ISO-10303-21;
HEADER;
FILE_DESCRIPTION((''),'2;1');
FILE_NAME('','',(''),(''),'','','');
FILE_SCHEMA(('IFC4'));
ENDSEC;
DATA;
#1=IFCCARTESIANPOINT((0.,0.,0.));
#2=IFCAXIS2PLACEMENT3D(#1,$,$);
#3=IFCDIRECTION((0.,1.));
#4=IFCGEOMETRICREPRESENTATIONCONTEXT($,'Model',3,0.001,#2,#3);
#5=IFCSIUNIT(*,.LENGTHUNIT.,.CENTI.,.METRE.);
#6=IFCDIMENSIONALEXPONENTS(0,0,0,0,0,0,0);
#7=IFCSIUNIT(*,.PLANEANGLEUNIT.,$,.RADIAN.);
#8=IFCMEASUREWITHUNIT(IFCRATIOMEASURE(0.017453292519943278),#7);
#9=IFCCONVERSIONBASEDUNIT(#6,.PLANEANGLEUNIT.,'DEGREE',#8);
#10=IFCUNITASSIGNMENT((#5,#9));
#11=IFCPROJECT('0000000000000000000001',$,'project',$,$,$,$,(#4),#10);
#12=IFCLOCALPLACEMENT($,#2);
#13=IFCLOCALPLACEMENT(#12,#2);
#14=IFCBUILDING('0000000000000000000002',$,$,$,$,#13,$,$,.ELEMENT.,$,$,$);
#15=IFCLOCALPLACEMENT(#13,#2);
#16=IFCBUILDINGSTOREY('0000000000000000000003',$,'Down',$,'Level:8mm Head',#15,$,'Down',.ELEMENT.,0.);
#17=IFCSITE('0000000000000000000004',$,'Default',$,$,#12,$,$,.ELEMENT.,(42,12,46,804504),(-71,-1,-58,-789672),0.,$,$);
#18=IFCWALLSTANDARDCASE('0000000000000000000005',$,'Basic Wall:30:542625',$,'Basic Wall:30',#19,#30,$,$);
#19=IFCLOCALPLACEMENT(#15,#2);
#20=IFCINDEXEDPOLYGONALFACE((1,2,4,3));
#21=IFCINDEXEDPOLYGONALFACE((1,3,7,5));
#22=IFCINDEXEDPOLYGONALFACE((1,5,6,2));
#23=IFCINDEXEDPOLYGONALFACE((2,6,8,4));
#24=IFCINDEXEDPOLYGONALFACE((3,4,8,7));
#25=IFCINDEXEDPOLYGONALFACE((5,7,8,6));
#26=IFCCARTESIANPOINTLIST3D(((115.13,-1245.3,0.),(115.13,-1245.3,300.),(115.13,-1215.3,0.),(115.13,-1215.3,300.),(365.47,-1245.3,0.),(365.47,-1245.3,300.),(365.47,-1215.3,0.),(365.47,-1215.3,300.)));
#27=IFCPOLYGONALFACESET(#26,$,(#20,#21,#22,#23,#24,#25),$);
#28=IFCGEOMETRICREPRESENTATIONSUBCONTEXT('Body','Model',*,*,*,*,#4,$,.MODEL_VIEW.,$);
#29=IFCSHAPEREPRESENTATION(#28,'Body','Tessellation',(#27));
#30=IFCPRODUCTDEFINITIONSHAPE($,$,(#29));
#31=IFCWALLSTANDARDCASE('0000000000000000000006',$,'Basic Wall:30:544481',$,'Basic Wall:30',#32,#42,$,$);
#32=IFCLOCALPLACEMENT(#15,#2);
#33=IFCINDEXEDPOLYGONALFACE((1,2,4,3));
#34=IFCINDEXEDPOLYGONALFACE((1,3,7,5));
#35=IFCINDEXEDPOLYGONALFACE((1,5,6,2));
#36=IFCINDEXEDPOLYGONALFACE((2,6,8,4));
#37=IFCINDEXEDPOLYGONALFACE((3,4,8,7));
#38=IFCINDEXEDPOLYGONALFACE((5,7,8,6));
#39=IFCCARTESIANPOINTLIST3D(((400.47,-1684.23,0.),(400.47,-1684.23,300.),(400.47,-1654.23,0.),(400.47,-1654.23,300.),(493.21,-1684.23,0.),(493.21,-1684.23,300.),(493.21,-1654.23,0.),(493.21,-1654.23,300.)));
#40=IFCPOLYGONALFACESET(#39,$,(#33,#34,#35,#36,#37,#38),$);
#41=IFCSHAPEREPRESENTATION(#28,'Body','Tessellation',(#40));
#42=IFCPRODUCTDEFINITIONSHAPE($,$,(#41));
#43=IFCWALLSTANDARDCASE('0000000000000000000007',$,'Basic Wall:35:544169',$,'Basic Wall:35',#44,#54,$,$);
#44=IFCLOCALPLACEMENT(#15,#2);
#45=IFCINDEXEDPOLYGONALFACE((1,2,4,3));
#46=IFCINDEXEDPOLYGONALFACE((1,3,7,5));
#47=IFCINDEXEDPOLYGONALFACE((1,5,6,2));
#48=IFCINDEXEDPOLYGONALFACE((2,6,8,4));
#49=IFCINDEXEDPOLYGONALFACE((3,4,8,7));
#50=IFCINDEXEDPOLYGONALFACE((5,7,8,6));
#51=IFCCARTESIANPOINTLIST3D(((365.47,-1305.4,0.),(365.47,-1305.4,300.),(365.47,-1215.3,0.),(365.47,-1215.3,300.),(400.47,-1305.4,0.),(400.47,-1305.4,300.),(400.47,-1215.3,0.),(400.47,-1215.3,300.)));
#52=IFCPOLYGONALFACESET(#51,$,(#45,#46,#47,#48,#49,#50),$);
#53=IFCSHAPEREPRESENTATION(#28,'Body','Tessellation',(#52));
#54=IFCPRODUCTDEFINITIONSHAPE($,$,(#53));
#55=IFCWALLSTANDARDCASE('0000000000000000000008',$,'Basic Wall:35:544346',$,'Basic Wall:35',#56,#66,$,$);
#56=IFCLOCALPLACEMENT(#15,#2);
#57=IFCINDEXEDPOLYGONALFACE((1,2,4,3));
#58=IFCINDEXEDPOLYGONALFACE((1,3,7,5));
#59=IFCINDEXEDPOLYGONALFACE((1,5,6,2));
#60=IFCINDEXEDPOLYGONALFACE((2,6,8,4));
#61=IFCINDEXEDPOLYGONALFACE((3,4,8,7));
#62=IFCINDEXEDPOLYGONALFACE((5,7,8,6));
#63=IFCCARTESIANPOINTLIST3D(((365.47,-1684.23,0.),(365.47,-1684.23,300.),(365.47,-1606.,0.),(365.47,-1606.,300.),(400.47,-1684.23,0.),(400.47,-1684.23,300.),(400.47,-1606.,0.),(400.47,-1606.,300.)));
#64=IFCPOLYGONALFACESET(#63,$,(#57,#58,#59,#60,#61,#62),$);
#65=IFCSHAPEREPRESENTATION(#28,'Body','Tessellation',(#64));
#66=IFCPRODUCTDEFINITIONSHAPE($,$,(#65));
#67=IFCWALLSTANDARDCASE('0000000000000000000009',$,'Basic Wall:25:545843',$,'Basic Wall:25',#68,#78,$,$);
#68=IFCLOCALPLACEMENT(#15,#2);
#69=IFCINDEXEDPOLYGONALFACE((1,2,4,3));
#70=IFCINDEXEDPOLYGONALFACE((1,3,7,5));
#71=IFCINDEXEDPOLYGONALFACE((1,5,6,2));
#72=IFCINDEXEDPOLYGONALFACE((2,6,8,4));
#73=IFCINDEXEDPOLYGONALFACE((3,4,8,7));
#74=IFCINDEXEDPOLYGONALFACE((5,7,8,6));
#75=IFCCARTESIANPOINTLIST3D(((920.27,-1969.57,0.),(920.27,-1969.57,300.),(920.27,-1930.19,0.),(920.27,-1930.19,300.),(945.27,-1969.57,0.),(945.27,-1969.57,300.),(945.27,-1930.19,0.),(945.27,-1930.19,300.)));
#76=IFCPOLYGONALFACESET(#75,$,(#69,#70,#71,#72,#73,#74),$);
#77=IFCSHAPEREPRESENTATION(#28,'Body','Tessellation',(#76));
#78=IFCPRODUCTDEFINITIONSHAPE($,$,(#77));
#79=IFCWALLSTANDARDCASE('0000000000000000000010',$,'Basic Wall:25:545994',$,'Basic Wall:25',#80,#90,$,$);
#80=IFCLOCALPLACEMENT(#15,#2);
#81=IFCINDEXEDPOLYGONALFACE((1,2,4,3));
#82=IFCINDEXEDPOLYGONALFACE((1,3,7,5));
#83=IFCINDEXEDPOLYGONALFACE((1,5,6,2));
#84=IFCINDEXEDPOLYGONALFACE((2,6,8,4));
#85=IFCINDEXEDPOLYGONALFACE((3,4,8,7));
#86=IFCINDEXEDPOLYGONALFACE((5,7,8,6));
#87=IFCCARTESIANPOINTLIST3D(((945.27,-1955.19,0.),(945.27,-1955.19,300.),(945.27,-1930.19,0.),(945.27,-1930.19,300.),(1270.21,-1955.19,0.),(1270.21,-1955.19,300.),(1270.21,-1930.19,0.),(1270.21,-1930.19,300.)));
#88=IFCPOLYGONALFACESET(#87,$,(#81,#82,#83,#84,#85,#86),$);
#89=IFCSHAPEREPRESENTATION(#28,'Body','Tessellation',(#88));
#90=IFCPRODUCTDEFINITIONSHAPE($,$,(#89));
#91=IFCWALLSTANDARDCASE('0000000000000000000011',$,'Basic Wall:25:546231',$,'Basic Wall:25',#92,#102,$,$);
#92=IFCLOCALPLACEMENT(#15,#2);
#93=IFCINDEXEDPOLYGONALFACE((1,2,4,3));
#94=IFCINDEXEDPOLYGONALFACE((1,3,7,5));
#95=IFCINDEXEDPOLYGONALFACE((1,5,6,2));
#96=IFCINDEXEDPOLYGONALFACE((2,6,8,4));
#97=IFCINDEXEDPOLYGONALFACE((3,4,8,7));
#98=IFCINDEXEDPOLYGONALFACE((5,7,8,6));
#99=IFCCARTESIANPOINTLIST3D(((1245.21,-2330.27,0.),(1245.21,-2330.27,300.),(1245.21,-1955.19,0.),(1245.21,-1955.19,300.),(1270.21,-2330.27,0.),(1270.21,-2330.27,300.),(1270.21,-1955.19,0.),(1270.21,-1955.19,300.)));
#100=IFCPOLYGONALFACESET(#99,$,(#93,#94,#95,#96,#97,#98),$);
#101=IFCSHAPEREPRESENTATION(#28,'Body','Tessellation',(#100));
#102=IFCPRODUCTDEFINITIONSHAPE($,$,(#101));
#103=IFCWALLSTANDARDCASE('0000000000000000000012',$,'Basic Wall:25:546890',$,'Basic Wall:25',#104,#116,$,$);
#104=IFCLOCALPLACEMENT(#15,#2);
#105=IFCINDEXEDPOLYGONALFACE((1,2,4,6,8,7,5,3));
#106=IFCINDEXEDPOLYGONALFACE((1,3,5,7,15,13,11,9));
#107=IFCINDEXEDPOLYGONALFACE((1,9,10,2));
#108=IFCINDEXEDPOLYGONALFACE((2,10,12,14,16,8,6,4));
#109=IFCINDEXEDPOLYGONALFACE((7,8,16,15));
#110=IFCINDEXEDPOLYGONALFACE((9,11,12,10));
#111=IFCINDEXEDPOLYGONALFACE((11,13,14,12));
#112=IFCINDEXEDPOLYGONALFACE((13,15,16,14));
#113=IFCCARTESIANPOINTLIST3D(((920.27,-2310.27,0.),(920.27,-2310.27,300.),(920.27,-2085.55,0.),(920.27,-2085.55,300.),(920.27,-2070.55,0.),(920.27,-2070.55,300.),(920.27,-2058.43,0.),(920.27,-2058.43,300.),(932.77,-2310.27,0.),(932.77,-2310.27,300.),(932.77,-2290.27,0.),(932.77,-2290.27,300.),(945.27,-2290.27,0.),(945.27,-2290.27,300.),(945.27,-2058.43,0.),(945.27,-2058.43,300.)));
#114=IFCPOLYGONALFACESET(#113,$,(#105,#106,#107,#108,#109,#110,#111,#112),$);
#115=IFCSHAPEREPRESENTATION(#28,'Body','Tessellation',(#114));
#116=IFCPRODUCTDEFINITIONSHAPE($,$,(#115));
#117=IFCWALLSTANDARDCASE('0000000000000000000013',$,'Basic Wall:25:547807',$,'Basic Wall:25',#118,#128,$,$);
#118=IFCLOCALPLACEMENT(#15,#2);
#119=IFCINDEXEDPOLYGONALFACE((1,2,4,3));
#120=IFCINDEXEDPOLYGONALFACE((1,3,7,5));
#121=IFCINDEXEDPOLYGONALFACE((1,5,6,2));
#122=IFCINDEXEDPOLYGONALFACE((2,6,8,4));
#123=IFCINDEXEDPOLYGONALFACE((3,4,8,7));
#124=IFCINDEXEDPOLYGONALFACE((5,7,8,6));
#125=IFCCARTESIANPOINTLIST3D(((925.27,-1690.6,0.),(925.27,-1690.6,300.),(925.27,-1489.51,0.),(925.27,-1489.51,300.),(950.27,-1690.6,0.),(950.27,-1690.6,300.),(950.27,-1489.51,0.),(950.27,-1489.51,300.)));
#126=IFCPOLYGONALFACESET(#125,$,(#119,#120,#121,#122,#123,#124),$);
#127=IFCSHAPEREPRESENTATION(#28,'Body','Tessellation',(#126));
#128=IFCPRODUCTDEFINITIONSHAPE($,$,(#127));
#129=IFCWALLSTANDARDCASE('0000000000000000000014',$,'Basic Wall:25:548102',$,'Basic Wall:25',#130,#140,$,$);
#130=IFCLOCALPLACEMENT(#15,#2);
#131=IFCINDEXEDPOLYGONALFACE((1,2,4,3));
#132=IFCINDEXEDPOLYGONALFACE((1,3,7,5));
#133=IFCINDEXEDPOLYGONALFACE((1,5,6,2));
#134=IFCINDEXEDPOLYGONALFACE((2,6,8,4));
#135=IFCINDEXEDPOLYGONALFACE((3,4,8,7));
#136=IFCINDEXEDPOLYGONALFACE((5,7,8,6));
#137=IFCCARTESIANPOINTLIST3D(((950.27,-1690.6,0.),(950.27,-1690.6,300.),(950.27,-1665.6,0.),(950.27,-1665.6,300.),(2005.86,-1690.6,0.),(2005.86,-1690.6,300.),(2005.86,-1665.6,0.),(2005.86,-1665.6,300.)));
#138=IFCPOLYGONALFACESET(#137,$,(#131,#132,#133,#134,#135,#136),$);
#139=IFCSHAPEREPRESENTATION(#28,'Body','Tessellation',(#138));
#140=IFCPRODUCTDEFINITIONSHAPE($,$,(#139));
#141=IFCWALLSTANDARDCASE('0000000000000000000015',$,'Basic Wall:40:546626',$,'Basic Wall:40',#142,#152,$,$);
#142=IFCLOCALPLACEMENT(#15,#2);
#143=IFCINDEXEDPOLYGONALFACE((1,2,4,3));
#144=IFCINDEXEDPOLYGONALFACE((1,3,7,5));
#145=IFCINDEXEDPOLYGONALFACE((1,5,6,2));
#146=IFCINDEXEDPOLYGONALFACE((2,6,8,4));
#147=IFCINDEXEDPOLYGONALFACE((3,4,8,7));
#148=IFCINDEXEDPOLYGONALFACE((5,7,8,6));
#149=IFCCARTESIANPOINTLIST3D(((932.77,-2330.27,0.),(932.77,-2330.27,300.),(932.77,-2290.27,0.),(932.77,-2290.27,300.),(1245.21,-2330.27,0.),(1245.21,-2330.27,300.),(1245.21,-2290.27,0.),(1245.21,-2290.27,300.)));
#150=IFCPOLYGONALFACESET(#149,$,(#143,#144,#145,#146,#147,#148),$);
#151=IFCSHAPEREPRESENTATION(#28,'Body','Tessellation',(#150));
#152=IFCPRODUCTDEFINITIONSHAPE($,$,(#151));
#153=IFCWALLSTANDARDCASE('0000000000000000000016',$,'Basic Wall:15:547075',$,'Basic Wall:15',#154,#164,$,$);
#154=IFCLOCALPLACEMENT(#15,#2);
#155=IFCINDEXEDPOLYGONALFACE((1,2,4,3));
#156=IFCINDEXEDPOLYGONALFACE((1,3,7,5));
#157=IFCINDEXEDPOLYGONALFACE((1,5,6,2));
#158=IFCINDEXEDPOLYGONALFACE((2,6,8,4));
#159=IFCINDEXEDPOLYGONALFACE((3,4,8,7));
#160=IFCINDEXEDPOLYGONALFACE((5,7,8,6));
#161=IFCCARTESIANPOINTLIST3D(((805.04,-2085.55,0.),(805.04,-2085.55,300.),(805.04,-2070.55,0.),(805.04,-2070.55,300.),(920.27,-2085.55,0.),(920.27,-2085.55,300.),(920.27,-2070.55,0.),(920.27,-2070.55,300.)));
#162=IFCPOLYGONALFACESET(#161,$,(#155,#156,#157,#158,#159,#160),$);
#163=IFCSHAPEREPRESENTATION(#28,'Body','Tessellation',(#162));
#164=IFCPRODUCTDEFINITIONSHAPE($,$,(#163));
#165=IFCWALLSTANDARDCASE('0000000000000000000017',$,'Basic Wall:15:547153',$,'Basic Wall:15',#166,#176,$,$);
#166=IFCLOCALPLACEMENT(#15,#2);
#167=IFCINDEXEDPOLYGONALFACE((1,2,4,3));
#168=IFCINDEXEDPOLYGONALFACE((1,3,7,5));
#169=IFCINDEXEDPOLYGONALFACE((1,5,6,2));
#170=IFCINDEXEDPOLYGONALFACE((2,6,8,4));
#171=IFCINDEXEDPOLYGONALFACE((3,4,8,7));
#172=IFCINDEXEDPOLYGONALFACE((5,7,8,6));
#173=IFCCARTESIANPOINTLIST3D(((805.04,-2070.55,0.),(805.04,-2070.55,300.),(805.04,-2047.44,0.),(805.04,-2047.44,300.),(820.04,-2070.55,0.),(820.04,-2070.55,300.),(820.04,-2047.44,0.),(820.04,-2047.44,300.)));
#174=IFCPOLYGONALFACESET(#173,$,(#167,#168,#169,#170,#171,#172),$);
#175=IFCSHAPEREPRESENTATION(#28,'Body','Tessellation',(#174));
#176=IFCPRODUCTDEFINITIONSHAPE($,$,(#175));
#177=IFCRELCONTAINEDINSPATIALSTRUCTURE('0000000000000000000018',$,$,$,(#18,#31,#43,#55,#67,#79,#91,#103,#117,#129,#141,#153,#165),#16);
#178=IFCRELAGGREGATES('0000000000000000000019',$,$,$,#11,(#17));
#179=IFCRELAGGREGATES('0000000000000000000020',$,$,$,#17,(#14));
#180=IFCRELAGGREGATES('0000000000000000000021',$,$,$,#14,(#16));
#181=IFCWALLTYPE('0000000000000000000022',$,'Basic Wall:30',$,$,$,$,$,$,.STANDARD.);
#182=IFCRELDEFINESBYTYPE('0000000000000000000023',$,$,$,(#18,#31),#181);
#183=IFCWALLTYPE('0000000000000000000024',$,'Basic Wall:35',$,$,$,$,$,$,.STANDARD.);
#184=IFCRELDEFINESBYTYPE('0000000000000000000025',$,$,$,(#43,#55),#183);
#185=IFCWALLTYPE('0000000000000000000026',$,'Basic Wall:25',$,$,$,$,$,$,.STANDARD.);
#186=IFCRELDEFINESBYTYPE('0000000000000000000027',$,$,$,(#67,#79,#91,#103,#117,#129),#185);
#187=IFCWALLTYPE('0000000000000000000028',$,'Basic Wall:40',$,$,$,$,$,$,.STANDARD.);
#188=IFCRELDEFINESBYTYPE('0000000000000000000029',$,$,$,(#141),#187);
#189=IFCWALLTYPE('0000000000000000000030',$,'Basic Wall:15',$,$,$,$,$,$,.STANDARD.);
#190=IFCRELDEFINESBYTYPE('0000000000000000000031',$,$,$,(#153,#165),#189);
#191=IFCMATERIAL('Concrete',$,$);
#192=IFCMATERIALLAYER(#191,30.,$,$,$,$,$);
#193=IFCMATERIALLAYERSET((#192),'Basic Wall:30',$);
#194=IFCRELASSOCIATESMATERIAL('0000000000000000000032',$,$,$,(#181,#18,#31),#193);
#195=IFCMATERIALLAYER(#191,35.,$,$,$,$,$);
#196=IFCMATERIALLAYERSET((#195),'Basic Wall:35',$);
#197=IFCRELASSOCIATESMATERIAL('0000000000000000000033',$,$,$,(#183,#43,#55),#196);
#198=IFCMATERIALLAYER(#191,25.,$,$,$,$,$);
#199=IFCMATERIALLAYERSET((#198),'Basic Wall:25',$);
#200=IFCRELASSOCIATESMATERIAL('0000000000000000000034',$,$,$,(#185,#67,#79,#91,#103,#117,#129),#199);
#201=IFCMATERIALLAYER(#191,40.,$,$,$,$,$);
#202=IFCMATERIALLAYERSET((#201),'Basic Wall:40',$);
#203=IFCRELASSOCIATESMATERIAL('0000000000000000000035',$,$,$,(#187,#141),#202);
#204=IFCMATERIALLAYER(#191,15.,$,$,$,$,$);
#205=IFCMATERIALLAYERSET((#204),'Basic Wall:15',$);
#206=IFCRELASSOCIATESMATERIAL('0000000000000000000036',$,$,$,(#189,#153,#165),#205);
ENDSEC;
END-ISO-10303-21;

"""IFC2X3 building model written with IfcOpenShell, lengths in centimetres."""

from ifc_helpers import new_model, entity, si_unit, converted_unit, direction, frame, frame_2d, origin, place, context, subcontext, project, spatial, polyline, rectangle, outline, extrude, material, layer, layer_set, layer_usage, type_object, element, save


model = new_model("IFC2X3")

# Units and contexts
model_context = context("Model", 3, precision=0.001, world=origin(), true_north=direction((0.0, 1.0)))
body_context = subcontext(model_context, "Body", "Model", "MODEL_VIEW")
ifc_project = project(units=[si_unit("LENGTHUNIT", "METRE", prefix="CENTI"), converted_unit("PLANEANGLEUNIT", "DEGREE", entity("IfcRatioMeasure", 0.017453292519943278), si_unit("PLANEANGLEUNIT", "RADIAN"), dimensions=[0, 0, 0, 0, 0, 0, 0])], contexts=[model_context])

# Site, building, storey
site_placement = place(None, origin())
site = spatial("IfcSite", under=ifc_project, at=site_placement, Name="Default", CompositionType="ELEMENT", RefLatitude=(42, 12, 46, 804504), RefLongitude=(-71, -1, -58, -789672), RefElevation=0.0)
building_placement = place(site_placement, origin())
building = spatial("IfcBuilding", under=site, at=building_placement, CompositionType="ELEMENT")
storey_placement = place(building_placement, origin())
storey = spatial("IfcBuildingStorey", under=building, at=storey_placement, Name="Down", ObjectType="Level:8mm Head", LongName="Down", CompositionType="ELEMENT", Elevation=0.0)

# Walls
ifc_material = material(Name="Concrete")
ifc_layer_1 = layer(ifc_material, 30.0)
ifc_layer_set_1 = layer_set([ifc_layer_1], Name="Basic Wall:30")
ifc_layer_usage_1 = layer_usage(ifc_layer_set_1, "AXIS2", "NEGATIVE", 15.0)
wall_type_1 = type_object("IfcWallType", Name="Basic Wall:30", PredefinedType="STANDARD", material=ifc_layer_set_1)
wall_1_placement = place(storey_placement, frame((115.13, -1230.3, 0.0)))
element("IfcWallStandardCase", 1, at=wall_1_placement, inside=storey, type_object=wall_type_1, material=ifc_layer_usage_1, Name="Basic Wall:30:542625", ObjectType="Basic Wall:30", context=body_context, shape_type="SweptSolid", body=[
    extrude(rectangle(XDim=250.34, YDim=30.0, at=frame_2d((125.17, 0.0), x_axis=(-1.0, 0.0))), origin(), (0.0, 0.0, 1.0), 300.0),
])
ifc_layer_usage_2 = layer_usage(ifc_layer_set_1, "AXIS2", "POSITIVE", -15.0)
wall_2_placement = place(storey_placement, frame((400.47, -1669.23, 0.0)))
element("IfcWallStandardCase", 2, at=wall_2_placement, inside=storey, type_object=wall_type_1, material=ifc_layer_usage_2, Name="Basic Wall:30:544481", ObjectType="Basic Wall:30", context=body_context, shape_type="SweptSolid", body=[
    extrude(rectangle(XDim=92.73, YDim=30.0, at=frame_2d((46.37, 0.0), x_axis=(-1.0, 0.0))), origin(), (0.0, 0.0, 1.0), 300.0),
])
ifc_layer_2 = layer(ifc_material, 35.0)
ifc_layer_set_2 = layer_set([ifc_layer_2], Name="Basic Wall:35")
ifc_layer_usage_3 = layer_usage(ifc_layer_set_2, "AXIS2", "NEGATIVE", 17.5)
wall_type_2 = type_object("IfcWallType", Name="Basic Wall:35", PredefinedType="STANDARD", material=ifc_layer_set_2)
wall_3_placement = place(storey_placement, frame((382.97, -1215.3, 0.0), z_axis=(0.0, 0.0, 1.0), x_axis=(0.0, -1.0, 0.0)))
element("IfcWallStandardCase", 3, at=wall_3_placement, inside=storey, type_object=wall_type_2, material=ifc_layer_usage_3, Name="Basic Wall:35:544169", ObjectType="Basic Wall:35", context=body_context, shape_type="SweptSolid", body=[
    extrude(rectangle(XDim=90.1, YDim=35.0, at=frame_2d((45.05, 0.0), x_axis=(-1.0, 0.0))), origin(), (0.0, 0.0, 1.0), 300.0),
])
ifc_layer_usage_4 = layer_usage(ifc_layer_set_2, "AXIS2", "NEGATIVE", 17.5)
wall_4_placement = place(storey_placement, frame((382.97, -1606.0, 0.0), z_axis=(0.0, 0.0, 1.0), x_axis=(0.0, -1.0, 0.0)))
element("IfcWallStandardCase", 4, at=wall_4_placement, inside=storey, type_object=wall_type_2, material=ifc_layer_usage_4, Name="Basic Wall:35:544346", ObjectType="Basic Wall:35", context=body_context, shape_type="SweptSolid", body=[
    extrude(rectangle(XDim=78.24, YDim=35.0, at=frame_2d((39.12, 0.0), x_axis=(-1.0, 0.0))), origin(), (0.0, 0.0, 1.0), 300.0),
])
ifc_layer_3 = layer(ifc_material, 25.0)
ifc_layer_set_3 = layer_set([ifc_layer_3], Name="Basic Wall:25")
ifc_layer_usage_5 = layer_usage(ifc_layer_set_3, "AXIS2", "NEGATIVE", 12.5)
wall_type_3 = type_object("IfcWallType", Name="Basic Wall:25", PredefinedType="STANDARD", material=ifc_layer_set_3)
wall_5_placement = place(storey_placement, frame((932.77, -1969.57, 0.0), z_axis=(0.0, 0.0, 1.0), x_axis=(0.0, 1.0, 0.0)))
element("IfcWallStandardCase", 5, at=wall_5_placement, inside=storey, type_object=wall_type_3, material=ifc_layer_usage_5, Name="Basic Wall:25:545843", ObjectType="Basic Wall:25", context=body_context, shape_type="SweptSolid", body=[
    extrude(rectangle(XDim=39.38, YDim=25.0, at=frame_2d((19.69, 0.0), x_axis=(-1.0, 0.0))), origin(), (0.0, 0.0, 1.0), 300.0),
])
ifc_layer_usage_6 = layer_usage(ifc_layer_set_3, "AXIS2", "NEGATIVE", 12.5)
wall_6_placement = place(storey_placement, frame((945.27, -1942.69, 0.0)))
element("IfcWallStandardCase", 6, at=wall_6_placement, inside=storey, type_object=wall_type_3, material=ifc_layer_usage_6, Name="Basic Wall:25:545994", ObjectType="Basic Wall:25", context=body_context, shape_type="SweptSolid", body=[
    extrude(rectangle(XDim=324.94, YDim=25.0, at=frame_2d((162.47, 0.0), x_axis=(-1.0, 0.0))), origin(), (0.0, 0.0, 1.0), 300.0),
])
ifc_layer_usage_7 = layer_usage(ifc_layer_set_3, "AXIS2", "NEGATIVE", 12.5)
wall_7_placement = place(storey_placement, frame((1257.71, -1955.19, 0.0), z_axis=(0.0, 0.0, 1.0), x_axis=(0.0, -1.0, 0.0)))
element("IfcWallStandardCase", 7, at=wall_7_placement, inside=storey, type_object=wall_type_3, material=ifc_layer_usage_7, Name="Basic Wall:25:546231", ObjectType="Basic Wall:25", context=body_context, shape_type="SweptSolid", body=[
    extrude(rectangle(XDim=375.08, YDim=25.0, at=frame_2d((187.54, 0.0), x_axis=(-1.0, 0.0))), origin(), (0.0, 0.0, 1.0), 300.0),
])
ifc_layer_usage_8 = layer_usage(ifc_layer_set_3, "AXIS2", "NEGATIVE", 12.5)
wall_8_placement = place(storey_placement, frame((932.77, -2310.27, 0.0), z_axis=(0.0, 0.0, 1.0), x_axis=(0.0, 1.0, 0.0)))
element("IfcWallStandardCase", 8, at=wall_8_placement, inside=storey, type_object=wall_type_3, material=ifc_layer_usage_8, Name="Basic Wall:25:546890", ObjectType="Basic Wall:25", context=body_context, shape_type="SweptSolid", body=[
    extrude(outline(polyline([(251.85, -12.5), (251.85, 12.5), (239.72, 12.5), (224.72, 12.5), (0.0, 12.5), (0.0, 0.0), (20.0, 0.0), (20.0, -12.5), (251.85, -12.5)])), origin(), (0.0, 0.0, 1.0), 300.0),
])
ifc_layer_usage_9 = layer_usage(ifc_layer_set_3, "AXIS2", "NEGATIVE", 12.5)
wall_9_placement = place(storey_placement, frame((937.77, -1489.51, 0.0), z_axis=(0.0, 0.0, 1.0), x_axis=(0.0, -1.0, 0.0)))
element("IfcWallStandardCase", 9, at=wall_9_placement, inside=storey, type_object=wall_type_3, material=ifc_layer_usage_9, Name="Basic Wall:25:547807", ObjectType="Basic Wall:25", context=body_context, shape_type="SweptSolid", body=[
    extrude(rectangle(XDim=201.09, YDim=25.0, at=frame_2d((100.55, 0.0), x_axis=(-1.0, 0.0))), origin(), (0.0, 0.0, 1.0), 300.0),
])
ifc_layer_usage_10 = layer_usage(ifc_layer_set_3, "AXIS2", "POSITIVE", -12.5)
wall_10_placement = place(storey_placement, frame((950.27, -1678.1, 0.0)))
element("IfcWallStandardCase", 10, at=wall_10_placement, inside=storey, type_object=wall_type_3, material=ifc_layer_usage_10, Name="Basic Wall:25:548102", ObjectType="Basic Wall:25", context=body_context, shape_type="SweptSolid", body=[
    extrude(rectangle(XDim=1055.59, YDim=25.0, at=frame_2d((527.8, 0.0), x_axis=(-1.0, 0.0))), origin(), (0.0, 0.0, 1.0), 300.0),
])
ifc_layer_4 = layer(ifc_material, 40.0)
ifc_layer_set_4 = layer_set([ifc_layer_4], Name="Basic Wall:40")
ifc_layer_usage_11 = layer_usage(ifc_layer_set_4, "AXIS2", "NEGATIVE", 20.0)
wall_type_4 = type_object("IfcWallType", Name="Basic Wall:40", PredefinedType="STANDARD", material=ifc_layer_set_4)
wall_11_placement = place(storey_placement, frame((1245.21, -2310.27, 0.0), z_axis=(0.0, 0.0, 1.0), x_axis=(-1.0, 0.0, 0.0)))
element("IfcWallStandardCase", 11, at=wall_11_placement, inside=storey, type_object=wall_type_4, material=ifc_layer_usage_11, Name="Basic Wall:40:546626", ObjectType="Basic Wall:40", context=body_context, shape_type="SweptSolid", body=[
    extrude(rectangle(XDim=312.44, YDim=40.0, at=frame_2d((156.22, 0.0), x_axis=(-1.0, 0.0))), origin(), (0.0, 0.0, 1.0), 300.0),
])
ifc_layer_5 = layer(ifc_material, 15.0)
ifc_layer_set_5 = layer_set([ifc_layer_5], Name="Basic Wall:15")
ifc_layer_usage_12 = layer_usage(ifc_layer_set_5, "AXIS2", "NEGATIVE", 7.5)
wall_type_5 = type_object("IfcWallType", Name="Basic Wall:15", PredefinedType="STANDARD", material=ifc_layer_set_5)
wall_12_placement = place(storey_placement, frame((920.27, -2078.05, 0.0), z_axis=(0.0, 0.0, 1.0), x_axis=(-1.0, 0.0, 0.0)))
element("IfcWallStandardCase", 12, at=wall_12_placement, inside=storey, type_object=wall_type_5, material=ifc_layer_usage_12, Name="Basic Wall:15:547075", ObjectType="Basic Wall:15", context=body_context, shape_type="SweptSolid", body=[
    extrude(rectangle(XDim=115.24, YDim=15.0, at=frame_2d((57.62, 0.0), x_axis=(-1.0, 0.0))), origin(), (0.0, 0.0, 1.0), 300.0),
])
ifc_layer_usage_13 = layer_usage(ifc_layer_set_5, "AXIS2", "NEGATIVE", 7.5)
wall_13_placement = place(storey_placement, frame((812.54, -2070.55, 0.0), z_axis=(0.0, 0.0, 1.0), x_axis=(0.0, 1.0, 0.0)))
element("IfcWallStandardCase", 13, at=wall_13_placement, inside=storey, type_object=wall_type_5, material=ifc_layer_usage_13, Name="Basic Wall:15:547153", ObjectType="Basic Wall:15", context=body_context, shape_type="SweptSolid", body=[
    extrude(rectangle(XDim=23.11, YDim=15.0, at=frame_2d((11.56, 0.0), x_axis=(-1.0, 0.0))), origin(), (0.0, 0.0, 1.0), 300.0),
])

save(model, "model.ifc")
